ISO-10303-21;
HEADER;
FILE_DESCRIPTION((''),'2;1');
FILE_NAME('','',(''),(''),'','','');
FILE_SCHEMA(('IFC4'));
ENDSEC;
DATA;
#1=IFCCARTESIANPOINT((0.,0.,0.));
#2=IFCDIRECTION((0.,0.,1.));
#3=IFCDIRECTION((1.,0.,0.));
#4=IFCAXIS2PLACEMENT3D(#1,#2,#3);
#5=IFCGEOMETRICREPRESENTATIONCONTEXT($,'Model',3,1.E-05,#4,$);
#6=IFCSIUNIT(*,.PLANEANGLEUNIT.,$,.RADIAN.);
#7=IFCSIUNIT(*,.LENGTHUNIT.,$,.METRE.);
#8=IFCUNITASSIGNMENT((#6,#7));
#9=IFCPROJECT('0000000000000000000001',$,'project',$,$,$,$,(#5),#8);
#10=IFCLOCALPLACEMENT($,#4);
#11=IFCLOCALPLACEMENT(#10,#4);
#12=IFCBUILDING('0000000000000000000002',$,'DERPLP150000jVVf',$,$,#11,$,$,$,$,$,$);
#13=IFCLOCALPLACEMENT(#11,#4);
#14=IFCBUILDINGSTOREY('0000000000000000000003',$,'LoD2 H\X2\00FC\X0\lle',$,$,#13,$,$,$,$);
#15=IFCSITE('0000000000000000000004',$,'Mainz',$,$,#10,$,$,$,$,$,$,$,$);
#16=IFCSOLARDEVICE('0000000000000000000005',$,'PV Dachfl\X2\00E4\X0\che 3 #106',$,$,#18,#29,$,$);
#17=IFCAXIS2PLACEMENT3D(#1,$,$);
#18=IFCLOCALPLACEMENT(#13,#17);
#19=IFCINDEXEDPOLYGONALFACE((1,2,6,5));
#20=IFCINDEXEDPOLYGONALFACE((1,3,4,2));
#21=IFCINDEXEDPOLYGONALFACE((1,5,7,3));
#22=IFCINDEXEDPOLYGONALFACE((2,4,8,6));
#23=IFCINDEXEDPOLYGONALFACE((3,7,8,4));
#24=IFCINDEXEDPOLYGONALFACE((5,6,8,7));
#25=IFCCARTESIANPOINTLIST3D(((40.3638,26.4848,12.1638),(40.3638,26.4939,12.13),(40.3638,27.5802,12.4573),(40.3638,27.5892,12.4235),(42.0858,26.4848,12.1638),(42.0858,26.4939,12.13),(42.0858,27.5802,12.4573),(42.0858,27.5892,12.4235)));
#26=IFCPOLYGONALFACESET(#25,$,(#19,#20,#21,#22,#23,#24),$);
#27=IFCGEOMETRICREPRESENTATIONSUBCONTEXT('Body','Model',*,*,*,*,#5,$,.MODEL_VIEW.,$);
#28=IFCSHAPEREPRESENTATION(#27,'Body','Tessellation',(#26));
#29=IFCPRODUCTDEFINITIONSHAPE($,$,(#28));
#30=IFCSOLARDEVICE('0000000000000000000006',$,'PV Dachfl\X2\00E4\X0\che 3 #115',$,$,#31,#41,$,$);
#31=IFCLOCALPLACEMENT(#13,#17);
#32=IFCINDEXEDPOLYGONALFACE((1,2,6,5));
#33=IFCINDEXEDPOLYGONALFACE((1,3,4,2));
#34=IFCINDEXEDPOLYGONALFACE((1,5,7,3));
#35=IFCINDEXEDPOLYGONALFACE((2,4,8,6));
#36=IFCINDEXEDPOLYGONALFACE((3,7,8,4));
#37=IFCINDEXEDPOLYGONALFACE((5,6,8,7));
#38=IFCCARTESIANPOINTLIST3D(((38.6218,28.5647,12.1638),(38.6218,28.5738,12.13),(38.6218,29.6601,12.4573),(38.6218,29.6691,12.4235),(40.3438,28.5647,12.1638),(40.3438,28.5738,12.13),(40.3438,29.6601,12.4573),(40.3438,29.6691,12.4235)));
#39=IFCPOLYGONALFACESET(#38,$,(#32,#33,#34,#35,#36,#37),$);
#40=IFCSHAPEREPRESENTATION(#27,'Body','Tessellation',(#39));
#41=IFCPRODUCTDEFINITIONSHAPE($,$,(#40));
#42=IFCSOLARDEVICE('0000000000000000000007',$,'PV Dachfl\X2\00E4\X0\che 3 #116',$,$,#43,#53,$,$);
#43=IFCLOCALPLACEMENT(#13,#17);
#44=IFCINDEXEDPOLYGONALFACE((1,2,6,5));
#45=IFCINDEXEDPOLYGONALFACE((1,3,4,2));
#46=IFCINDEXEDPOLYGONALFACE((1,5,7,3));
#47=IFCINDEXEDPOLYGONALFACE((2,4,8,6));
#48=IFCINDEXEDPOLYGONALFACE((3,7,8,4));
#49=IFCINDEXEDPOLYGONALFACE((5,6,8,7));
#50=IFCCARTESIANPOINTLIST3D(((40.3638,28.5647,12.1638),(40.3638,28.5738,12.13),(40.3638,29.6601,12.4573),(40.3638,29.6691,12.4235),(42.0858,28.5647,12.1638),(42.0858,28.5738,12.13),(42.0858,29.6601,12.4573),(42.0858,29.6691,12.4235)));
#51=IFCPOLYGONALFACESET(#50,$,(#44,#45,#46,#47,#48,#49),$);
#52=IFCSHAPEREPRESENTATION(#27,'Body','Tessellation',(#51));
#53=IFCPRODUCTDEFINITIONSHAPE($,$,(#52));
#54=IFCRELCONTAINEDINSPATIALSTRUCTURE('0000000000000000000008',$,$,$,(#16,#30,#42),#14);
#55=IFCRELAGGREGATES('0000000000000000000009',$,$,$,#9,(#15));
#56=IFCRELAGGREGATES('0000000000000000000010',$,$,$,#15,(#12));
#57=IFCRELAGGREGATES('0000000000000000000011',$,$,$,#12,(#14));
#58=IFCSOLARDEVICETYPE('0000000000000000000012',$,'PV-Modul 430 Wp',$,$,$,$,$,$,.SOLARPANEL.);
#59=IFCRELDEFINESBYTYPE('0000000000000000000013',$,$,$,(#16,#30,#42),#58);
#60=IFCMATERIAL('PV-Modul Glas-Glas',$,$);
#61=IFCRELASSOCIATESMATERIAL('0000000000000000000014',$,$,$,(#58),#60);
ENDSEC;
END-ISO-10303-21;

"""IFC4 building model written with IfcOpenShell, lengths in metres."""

from ifc_helpers import new_model, si_unit, frame, frame_2d, origin, origin_with_axes, place, context, subcontext, project, spatial, rectangle, extrude, source, transform, mapped, material, type_object, type_shapes, element, save


model = new_model("IFC4")

# Units and contexts
model_context = context("Model", 3, precision=1e-05, world=origin_with_axes())
body_context = subcontext(model_context, "Body", "Model", "MODEL_VIEW")
ifc_project = project(units=[si_unit("PLANEANGLEUNIT", "RADIAN"), si_unit("LENGTHUNIT", "METRE")], contexts=[model_context])

# Site, building, storey
site_placement = place(None, origin_with_axes())
site = spatial("IfcSite", under=ifc_project, at=site_placement, Name="Mainz")
building_placement = place(site_placement, origin_with_axes())
building = spatial("IfcBuilding", under=site, at=building_placement, Name="DERPLP150000jVVf")
storey_placement = place(building_placement, origin_with_axes())
storey = spatial("IfcBuildingStorey", under=building, at=storey_placement, Name="LoD2 Hülle")

# Solar devices
ifc_material = material(Name="PV-Modul Glas-Glas")
solar_device_type = type_object("IfcSolarDeviceType", Name="PV-Modul 430 Wp", PredefinedType="SOLARPANEL", material=ifc_material)
shared_shape = source(origin_with_axes(), body_context, "Body", "SweptSolid", [
    extrude(rectangle(XDim=1.722, YDim=1.134, at=frame_2d((0.861, 0.567))), origin(), (0.0, 0.0, 1.0), 0.035),
])
type_shapes(solar_device_type, [shared_shape])
for number, where, z_axis, x_axis, name in (
    (1, (40.3638, 26.4939, 12.13), (0.0, -0.258819, 0.965926), (1.0, 0.0, 0.0), "PV Dachfläche 3 #106"),
    (2, (38.6218, 28.5738, 12.13), (0.0, -0.258819, 0.965926), (1.0, 0.0, 0.0), "PV Dachfläche 3 #115"),
    (3, (40.3638, 28.5738, 12.13), (0.0, -0.258819, 0.965926), (1.0, 0.0, 0.0), "PV Dachfläche 3 #116"),
):
    element("IfcSolarDevice", number, at=place(storey_placement, frame(where, z_axis=z_axis, x_axis=x_axis)), inside=storey, type_object=solar_device_type, Name=name, context=body_context, shape_type="MappedRepresentation", body=[
        mapped(shared_shape, transform((0.0, 0.0, 0.0), x_axis=(1.0, 0.0, 0.0), y_axis=(0.0, 1.0, 0.0), z_axis=(0.0, 0.0, 1.0), scale=1.0)),
    ])

save(model, "model.ifc")
